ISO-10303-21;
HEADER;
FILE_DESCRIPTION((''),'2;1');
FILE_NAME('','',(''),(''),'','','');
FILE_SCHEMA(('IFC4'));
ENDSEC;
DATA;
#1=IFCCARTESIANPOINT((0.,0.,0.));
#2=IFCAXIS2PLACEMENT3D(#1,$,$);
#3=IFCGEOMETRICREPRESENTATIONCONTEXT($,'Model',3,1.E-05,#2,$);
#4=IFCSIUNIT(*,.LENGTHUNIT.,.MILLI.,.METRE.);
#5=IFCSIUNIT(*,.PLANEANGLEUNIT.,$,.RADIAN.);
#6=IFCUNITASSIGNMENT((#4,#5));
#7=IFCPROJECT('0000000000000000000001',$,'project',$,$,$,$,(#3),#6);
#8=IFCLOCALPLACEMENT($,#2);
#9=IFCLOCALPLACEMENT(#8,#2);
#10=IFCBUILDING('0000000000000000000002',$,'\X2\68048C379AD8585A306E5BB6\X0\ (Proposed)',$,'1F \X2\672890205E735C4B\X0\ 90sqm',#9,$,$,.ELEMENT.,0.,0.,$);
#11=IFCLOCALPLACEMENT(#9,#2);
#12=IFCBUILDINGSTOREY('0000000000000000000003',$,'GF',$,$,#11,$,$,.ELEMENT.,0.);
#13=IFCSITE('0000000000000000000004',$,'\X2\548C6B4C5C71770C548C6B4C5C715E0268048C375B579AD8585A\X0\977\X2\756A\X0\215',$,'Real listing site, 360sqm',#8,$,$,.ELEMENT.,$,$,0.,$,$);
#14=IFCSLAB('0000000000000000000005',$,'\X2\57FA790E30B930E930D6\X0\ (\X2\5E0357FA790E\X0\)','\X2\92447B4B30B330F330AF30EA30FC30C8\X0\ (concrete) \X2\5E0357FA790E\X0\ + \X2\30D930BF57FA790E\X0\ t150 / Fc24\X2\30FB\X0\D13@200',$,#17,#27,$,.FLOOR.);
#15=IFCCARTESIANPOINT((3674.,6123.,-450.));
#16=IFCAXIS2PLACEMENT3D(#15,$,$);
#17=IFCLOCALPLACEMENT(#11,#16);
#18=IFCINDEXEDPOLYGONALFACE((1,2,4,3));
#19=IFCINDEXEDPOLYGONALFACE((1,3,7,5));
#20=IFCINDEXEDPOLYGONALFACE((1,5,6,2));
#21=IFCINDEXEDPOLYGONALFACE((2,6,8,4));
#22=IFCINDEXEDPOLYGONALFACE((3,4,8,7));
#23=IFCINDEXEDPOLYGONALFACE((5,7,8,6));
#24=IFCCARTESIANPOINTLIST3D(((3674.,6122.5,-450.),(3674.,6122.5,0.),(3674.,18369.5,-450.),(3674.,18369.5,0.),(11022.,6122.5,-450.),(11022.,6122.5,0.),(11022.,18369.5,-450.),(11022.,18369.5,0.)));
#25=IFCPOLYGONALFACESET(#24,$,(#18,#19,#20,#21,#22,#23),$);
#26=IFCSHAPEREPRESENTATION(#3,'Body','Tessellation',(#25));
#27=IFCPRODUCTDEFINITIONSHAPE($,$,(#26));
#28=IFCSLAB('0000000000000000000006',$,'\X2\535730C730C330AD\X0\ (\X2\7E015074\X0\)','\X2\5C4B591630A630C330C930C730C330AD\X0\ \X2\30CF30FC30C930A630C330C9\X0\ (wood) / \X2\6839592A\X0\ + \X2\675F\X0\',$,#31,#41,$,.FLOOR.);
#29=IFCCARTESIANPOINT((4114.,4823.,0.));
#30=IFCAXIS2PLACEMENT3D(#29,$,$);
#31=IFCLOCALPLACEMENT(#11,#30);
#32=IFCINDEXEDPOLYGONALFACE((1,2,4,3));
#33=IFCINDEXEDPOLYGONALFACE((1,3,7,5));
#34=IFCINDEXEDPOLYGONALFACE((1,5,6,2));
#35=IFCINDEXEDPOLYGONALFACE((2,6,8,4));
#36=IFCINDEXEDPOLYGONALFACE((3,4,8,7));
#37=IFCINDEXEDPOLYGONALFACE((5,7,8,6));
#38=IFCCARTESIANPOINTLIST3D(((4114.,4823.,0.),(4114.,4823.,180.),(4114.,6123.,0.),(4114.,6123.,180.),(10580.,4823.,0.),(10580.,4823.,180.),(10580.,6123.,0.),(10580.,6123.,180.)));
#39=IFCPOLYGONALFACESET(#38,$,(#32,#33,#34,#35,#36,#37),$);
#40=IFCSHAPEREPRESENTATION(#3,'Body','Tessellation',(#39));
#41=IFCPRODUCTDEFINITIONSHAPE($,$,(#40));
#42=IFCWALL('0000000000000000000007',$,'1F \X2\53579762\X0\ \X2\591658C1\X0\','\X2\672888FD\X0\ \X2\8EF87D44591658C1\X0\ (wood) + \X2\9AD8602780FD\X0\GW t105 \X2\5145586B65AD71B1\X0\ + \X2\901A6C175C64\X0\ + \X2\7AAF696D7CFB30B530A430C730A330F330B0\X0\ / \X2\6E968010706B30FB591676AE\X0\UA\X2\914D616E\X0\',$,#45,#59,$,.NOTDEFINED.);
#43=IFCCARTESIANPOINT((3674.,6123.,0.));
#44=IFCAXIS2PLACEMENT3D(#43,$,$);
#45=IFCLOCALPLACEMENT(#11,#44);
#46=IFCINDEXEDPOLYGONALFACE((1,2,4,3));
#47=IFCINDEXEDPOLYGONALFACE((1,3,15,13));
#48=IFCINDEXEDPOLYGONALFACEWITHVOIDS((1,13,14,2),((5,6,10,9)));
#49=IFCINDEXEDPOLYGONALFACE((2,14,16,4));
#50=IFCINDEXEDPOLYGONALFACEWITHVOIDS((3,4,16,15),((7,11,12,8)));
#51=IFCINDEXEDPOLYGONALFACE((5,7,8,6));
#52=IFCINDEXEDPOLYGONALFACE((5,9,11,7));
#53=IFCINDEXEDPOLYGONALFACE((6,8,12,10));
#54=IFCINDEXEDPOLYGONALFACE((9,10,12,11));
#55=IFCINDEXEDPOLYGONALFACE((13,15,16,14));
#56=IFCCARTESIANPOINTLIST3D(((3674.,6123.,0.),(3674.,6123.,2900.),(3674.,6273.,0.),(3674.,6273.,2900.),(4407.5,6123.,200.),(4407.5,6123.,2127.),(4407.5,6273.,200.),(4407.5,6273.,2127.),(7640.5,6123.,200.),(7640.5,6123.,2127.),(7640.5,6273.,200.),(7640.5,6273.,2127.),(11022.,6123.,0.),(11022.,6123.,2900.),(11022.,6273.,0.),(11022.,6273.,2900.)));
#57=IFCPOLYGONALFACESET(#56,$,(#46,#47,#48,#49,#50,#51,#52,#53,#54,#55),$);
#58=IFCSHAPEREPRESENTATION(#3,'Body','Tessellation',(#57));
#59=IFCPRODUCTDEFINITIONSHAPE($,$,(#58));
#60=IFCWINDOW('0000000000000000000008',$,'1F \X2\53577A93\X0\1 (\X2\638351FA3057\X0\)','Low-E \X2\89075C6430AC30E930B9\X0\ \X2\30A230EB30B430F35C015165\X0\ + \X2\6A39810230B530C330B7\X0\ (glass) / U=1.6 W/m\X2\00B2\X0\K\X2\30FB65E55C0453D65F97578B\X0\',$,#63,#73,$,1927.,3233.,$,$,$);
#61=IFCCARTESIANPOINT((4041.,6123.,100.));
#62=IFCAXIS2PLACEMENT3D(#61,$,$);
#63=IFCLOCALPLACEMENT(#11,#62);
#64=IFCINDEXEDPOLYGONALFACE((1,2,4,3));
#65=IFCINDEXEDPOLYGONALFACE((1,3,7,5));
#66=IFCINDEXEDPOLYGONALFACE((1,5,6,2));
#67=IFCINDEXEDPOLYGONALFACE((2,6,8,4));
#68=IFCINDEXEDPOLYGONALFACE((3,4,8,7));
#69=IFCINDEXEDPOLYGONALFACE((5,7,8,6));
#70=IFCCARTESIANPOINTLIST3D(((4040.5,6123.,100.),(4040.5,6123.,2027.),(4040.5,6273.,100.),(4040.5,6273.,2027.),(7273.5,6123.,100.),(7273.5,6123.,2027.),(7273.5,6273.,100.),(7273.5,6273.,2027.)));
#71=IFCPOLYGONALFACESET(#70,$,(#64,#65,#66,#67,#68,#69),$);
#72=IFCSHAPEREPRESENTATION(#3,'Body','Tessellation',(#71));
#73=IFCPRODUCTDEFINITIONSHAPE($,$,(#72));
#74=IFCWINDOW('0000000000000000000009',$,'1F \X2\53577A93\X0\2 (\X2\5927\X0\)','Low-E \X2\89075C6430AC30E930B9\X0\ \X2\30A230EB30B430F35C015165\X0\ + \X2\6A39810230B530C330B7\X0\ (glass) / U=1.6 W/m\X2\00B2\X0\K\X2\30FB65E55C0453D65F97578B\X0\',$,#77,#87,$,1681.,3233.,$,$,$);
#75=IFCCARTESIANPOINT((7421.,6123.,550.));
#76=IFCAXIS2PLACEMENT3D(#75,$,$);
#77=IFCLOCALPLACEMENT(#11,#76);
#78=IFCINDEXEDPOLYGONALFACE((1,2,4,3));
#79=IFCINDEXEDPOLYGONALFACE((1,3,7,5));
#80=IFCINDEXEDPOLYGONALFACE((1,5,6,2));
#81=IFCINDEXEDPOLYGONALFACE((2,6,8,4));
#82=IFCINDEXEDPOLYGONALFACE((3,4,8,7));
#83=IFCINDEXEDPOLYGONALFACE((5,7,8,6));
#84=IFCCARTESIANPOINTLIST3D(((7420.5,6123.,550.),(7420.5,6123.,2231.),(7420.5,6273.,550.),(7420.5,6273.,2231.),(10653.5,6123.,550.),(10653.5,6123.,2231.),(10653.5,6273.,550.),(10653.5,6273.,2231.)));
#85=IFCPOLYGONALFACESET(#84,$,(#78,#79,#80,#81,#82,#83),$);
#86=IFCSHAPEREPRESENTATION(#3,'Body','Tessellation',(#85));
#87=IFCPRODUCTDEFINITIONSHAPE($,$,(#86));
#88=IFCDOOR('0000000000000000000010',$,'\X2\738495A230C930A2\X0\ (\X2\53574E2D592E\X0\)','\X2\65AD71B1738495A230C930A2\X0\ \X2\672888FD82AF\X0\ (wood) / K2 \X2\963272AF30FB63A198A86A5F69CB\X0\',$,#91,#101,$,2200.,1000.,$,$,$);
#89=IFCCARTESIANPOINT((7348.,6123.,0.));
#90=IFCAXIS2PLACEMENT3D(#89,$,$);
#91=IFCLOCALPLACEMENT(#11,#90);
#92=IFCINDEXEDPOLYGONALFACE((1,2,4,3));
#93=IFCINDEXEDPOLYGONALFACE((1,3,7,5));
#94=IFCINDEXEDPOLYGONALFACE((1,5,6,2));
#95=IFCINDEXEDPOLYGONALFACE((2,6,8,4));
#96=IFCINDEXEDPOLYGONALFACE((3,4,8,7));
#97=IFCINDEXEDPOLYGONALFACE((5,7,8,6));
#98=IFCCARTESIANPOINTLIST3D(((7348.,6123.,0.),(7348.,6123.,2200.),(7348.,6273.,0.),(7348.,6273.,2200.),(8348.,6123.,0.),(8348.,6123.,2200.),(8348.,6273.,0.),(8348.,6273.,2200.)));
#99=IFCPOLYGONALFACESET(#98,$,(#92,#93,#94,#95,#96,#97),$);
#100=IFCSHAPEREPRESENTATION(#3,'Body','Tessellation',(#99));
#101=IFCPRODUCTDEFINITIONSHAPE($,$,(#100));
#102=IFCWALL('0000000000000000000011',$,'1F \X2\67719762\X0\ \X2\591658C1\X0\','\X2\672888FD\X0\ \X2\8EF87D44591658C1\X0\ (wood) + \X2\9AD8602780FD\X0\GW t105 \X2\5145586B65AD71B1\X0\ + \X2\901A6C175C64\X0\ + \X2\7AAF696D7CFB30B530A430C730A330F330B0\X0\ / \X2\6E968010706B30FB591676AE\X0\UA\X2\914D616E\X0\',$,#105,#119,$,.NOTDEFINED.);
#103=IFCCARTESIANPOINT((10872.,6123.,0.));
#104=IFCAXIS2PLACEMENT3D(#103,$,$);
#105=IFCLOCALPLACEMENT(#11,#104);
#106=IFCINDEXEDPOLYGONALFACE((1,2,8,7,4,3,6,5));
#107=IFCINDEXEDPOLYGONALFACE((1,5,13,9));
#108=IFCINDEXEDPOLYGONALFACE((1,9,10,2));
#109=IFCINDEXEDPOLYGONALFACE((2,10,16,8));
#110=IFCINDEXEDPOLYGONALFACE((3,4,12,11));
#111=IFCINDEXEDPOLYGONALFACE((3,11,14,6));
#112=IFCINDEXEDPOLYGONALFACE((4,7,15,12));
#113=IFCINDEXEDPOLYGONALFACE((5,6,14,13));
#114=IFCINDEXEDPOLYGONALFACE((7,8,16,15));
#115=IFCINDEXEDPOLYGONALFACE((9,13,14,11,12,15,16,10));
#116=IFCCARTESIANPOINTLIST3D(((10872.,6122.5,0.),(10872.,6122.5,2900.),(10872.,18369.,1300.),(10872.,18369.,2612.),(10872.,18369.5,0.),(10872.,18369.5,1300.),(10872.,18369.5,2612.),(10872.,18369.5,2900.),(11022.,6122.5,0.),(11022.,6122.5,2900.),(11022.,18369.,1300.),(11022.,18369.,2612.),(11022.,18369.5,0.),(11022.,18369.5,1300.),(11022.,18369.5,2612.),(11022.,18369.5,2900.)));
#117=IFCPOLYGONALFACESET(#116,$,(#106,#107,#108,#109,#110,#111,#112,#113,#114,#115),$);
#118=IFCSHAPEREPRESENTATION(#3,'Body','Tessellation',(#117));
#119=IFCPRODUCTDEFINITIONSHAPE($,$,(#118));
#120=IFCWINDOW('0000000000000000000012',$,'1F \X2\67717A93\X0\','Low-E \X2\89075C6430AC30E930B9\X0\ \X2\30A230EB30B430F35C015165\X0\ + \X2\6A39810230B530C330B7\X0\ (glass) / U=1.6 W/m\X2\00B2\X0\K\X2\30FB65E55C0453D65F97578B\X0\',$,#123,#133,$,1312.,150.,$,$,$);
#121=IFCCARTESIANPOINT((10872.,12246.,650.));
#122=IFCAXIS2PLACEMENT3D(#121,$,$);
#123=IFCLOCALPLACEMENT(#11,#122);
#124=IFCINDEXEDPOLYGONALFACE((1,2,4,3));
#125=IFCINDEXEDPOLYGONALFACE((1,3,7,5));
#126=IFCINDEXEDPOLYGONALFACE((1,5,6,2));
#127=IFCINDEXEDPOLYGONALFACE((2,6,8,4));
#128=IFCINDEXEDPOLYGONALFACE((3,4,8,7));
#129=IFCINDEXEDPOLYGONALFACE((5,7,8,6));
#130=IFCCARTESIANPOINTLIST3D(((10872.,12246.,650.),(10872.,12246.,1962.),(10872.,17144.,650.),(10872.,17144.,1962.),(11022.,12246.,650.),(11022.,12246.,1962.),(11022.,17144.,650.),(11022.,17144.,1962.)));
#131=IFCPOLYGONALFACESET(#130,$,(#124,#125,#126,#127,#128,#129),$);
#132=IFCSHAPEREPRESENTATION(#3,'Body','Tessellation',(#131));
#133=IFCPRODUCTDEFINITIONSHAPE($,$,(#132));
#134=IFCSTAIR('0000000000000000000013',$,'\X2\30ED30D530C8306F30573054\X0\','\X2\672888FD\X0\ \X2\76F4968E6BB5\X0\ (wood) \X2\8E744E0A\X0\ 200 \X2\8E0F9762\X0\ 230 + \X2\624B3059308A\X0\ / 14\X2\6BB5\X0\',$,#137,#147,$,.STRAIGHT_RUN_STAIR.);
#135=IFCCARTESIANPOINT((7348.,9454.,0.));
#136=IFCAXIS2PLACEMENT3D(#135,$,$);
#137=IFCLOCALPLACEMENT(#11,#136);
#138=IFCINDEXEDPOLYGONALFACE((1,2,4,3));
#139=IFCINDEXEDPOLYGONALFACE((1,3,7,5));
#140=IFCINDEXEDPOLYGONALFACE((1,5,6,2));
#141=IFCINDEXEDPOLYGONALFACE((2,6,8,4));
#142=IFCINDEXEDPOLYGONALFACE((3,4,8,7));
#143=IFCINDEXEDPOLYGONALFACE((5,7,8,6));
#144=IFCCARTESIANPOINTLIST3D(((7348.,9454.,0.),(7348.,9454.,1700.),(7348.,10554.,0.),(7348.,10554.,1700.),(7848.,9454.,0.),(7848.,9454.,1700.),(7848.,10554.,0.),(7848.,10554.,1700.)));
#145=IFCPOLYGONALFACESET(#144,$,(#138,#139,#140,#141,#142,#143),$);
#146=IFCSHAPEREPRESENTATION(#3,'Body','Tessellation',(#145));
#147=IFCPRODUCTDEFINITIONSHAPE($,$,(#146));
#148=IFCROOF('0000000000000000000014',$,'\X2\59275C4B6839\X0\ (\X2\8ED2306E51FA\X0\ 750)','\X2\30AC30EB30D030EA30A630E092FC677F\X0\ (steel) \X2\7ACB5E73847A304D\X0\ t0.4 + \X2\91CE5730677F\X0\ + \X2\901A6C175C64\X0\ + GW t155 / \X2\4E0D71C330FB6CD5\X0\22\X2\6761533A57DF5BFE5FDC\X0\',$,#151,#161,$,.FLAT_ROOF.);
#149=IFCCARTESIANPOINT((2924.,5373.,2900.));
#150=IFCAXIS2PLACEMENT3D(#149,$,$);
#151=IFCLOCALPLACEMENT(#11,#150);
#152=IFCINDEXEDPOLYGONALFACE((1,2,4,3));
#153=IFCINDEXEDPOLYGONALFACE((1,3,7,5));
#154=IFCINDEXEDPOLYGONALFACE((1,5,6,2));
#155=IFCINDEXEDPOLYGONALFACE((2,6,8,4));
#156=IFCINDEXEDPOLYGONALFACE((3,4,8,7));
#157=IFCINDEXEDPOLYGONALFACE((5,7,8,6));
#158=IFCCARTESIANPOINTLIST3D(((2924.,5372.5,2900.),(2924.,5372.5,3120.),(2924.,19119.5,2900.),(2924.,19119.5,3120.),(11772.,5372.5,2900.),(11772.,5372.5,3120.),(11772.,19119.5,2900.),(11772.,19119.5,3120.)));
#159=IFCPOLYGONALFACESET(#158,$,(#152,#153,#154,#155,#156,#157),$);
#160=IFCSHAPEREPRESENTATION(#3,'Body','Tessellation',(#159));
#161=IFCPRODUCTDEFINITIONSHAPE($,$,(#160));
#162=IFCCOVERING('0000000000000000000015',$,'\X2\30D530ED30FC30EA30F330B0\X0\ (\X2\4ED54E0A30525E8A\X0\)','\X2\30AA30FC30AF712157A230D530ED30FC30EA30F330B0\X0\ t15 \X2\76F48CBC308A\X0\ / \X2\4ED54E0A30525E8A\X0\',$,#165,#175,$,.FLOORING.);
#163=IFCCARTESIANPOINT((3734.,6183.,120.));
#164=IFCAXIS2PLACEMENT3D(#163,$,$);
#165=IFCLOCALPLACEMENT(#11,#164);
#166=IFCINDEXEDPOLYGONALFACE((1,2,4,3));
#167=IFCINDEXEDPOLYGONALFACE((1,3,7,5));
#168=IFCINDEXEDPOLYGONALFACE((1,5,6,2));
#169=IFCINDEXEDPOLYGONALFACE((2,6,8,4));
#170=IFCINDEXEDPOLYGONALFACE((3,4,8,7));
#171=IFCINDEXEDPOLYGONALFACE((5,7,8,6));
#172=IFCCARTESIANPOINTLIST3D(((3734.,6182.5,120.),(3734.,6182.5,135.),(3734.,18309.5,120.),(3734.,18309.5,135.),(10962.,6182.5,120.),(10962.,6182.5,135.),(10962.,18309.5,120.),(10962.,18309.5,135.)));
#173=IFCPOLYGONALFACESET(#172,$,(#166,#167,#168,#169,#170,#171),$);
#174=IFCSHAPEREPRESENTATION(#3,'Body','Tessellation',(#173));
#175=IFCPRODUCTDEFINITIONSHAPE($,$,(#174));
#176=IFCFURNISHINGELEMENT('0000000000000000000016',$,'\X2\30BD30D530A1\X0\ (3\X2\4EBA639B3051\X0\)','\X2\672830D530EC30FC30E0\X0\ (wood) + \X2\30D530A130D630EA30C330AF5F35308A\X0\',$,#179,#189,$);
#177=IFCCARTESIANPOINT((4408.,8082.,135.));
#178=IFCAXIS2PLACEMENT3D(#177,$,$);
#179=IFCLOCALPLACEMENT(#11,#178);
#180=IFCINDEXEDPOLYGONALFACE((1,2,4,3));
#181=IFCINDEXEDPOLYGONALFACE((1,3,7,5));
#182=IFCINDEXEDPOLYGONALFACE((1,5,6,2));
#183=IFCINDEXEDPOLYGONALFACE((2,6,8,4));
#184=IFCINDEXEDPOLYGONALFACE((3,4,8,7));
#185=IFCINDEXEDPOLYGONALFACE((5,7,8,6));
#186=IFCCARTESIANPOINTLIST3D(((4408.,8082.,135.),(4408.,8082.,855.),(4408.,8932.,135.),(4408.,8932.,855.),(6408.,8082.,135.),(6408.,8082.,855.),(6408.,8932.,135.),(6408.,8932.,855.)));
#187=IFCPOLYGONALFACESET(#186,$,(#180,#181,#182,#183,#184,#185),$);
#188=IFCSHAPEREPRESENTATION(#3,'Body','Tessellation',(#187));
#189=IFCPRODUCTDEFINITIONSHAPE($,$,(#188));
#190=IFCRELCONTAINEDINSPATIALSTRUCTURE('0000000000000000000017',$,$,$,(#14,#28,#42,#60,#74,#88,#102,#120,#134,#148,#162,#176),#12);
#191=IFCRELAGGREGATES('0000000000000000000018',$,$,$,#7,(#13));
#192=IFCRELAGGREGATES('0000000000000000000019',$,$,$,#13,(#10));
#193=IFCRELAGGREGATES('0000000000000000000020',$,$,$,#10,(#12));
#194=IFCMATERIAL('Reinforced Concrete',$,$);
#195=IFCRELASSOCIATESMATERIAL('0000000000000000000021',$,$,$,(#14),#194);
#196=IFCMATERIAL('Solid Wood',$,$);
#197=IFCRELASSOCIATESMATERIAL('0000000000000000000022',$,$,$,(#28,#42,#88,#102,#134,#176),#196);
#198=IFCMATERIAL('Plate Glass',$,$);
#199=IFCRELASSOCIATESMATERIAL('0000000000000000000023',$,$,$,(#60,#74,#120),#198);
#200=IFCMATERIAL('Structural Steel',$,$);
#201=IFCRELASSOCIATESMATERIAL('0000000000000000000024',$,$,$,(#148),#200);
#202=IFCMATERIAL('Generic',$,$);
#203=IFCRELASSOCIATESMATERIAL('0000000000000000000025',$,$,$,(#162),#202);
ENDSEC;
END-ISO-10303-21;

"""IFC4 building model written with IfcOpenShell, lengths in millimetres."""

from ifc_helpers import new_model, si_unit, frame, frame_2d, origin, place, context, project, spatial, rectangle, extrude, material, element, fill, save


model = new_model("IFC4")

# Units and contexts
model_context = context("Model", 3, precision=1e-05, world=origin())
ifc_project = project(units=[si_unit("LENGTHUNIT", "METRE", prefix="MILLI"), si_unit("PLANEANGLEUNIT", "RADIAN")], contexts=[model_context])

# Site, building, storey
site_placement = place(None, origin())
site = spatial("IfcSite", under=ifc_project, at=site_placement, Name="和歌山県和歌山市栄谷字高塚977番215", ObjectType="Real listing site, 360sqm", CompositionType="ELEMENT", RefElevation=0.0)
building_placement = place(site_placement, origin())
building = spatial("IfcBuilding", under=site, at=building_placement, Name="栄谷高塚の家 (Proposed)", ObjectType="1F 木造平屋 90sqm", CompositionType="ELEMENT", ElevationOfRefHeight=0.0, ElevationOfTerrain=0.0)
storey_placement = place(building_placement, origin())
storey = spatial("IfcBuildingStorey", under=building, at=storey_placement, Name="GF", CompositionType="ELEMENT", Elevation=0.0)

# Slabs
ifc_material_1 = material(Name="Reinforced Concrete")
slab_1_placement = place(storey_placement, frame((3674.0, 6123.0, -450.0)))
element("IfcSlab", 1, at=slab_1_placement, inside=storey, material=ifc_material_1, Name="基礎スラブ (布基礎)", Description="鉄筋コンクリート (concrete) 布基礎 + ベタ基礎 t150 / Fc24・D13@200", PredefinedType="FLOOR", context=model_context, shape_type="SweptSolid", body=[
    extrude(rectangle(XDim=7348.0, YDim=12247.0, at=frame_2d((3674.0, 6123.0))), frame((3674.0, 6123.0, -450.0)), (0.0, 0.0, 1.0), 450.0),
])
ifc_material_2 = material(Name="Solid Wood")
slab_2_placement = place(storey_placement, frame((4114.0, 4823.0, 0.0)))
element("IfcSlab", 2, at=slab_2_placement, inside=storey, material=ifc_material_2, Name="南デッキ (縁側)", Description="屋外ウッドデッキ ハードウッド (wood) / 根太 + 束", PredefinedType="FLOOR", context=model_context, shape_type="SweptSolid", body=[
    extrude(rectangle(XDim=6466.0, YDim=1300.0, at=frame_2d((3233.0, 650.0))), frame((4114.0, 4823.0, 0.0)), (0.0, 0.0, 1.0), 180.0),
])

# Wall, openings, windows, door
wall_1_placement = place(storey_placement, frame((3674.0, 6123.0, 0.0)))
wall_1 = element("IfcWall", 3, at=wall_1_placement, inside=storey, material=ifc_material_2, Name="1F 南面 外壁", Description="木製 軸組外壁 (wood) + 高性能GW t105 充填断熱 + 通気層 + 窯業系サイディング / 準耐火・外皮UA配慮", PredefinedType="NOTDEFINED", context=model_context, shape_type="SweptSolid", body=[
    extrude(rectangle(XDim=7348.0, YDim=150.0, at=frame_2d((3674.0, 75.0))), frame((3674.0, 6123.0, 0.0)), (0.0, 0.0, 1.0), 2900.0),
])
opening_1_placement = place(storey_placement, frame((4041.0, 6123.0, 100.0)))
opening_1 = element("IfcOpeningElement", 4, at=opening_1_placement, cuts=wall_1, PredefinedType="NOTDEFINED", context=model_context, shape_type="SweptSolid", body=[
    extrude(rectangle(XDim=3233.0, YDim=150.0, at=frame_2d((1616.0, 75.0))), frame((4041.0, 6123.0, 100.0)), (0.0, 0.0, 1.0), 1927.0),
])
opening_2_placement = place(storey_placement, frame((7421.0, 6123.0, 550.0)))
opening_2 = element("IfcOpeningElement", 5, at=opening_2_placement, cuts=wall_1, PredefinedType="NOTDEFINED", context=model_context, shape_type="SweptSolid", body=[
    extrude(rectangle(XDim=3233.0, YDim=150.0, at=frame_2d((1616.0, 75.0))), frame((7421.0, 6123.0, 550.0)), (0.0, 0.0, 1.0), 1681.0),
])
opening_3_placement = place(storey_placement, frame((7348.0, 6123.0, 0.0)))
opening_3 = element("IfcOpeningElement", 6, at=opening_3_placement, cuts=wall_1, PredefinedType="NOTDEFINED", context=model_context, shape_type="SweptSolid", body=[
    extrude(rectangle(XDim=1000.0, YDim=150.0, at=frame_2d((500.0, 75.0))), frame((7348.0, 6123.0, 0.0)), (0.0, 0.0, 1.0), 2200.0),
])
ifc_material_3 = material(Name="Plate Glass")
window_1_placement = place(storey_placement, frame((4041.0, 6123.0, 100.0)))
window_1 = element("IfcWindow", 7, at=window_1_placement, inside=storey, material=ifc_material_3, Name="1F 南窓1 (掃出し)", Description="Low-E 複層ガラス アルゴン封入 + 樹脂サッシ (glass) / U=1.6 W/m²K・日射取得型", OverallHeight=1927.0, OverallWidth=3233.0, context=model_context, shape_type="SweptSolid", body=[
    extrude(rectangle(XDim=3233.0, YDim=150.0, at=frame_2d((1616.0, 75.0))), frame((4041.0, 6123.0, 100.0)), (0.0, 0.0, 1.0), 1927.0),
])
fill(opening_1, window_1)
window_2_placement = place(storey_placement, frame((7421.0, 6123.0, 550.0)))
window_2 = element("IfcWindow", 8, at=window_2_placement, inside=storey, material=ifc_material_3, Name="1F 南窓2 (大)", Description="Low-E 複層ガラス アルゴン封入 + 樹脂サッシ (glass) / U=1.6 W/m²K・日射取得型", OverallHeight=1681.0, OverallWidth=3233.0, context=model_context, shape_type="SweptSolid", body=[
    extrude(rectangle(XDim=3233.0, YDim=150.0, at=frame_2d((1616.0, 75.0))), frame((7421.0, 6123.0, 550.0)), (0.0, 0.0, 1.0), 1681.0),
])
fill(opening_2, window_2)
door_placement = place(storey_placement, frame((7348.0, 6123.0, 0.0)))
door = element("IfcDoor", 9, at=door_placement, inside=storey, material=ifc_material_2, Name="玄関ドア (南中央)", Description="断熱玄関ドア 木製芯 (wood) / K2 防犯・採風機構", OverallHeight=2200.0, OverallWidth=1000.0, context=model_context, shape_type="SweptSolid", body=[
    extrude(rectangle(XDim=1000.0, YDim=150.0, at=frame_2d((500.0, 75.0))), frame((7348.0, 6123.0, 0.0)), (0.0, 0.0, 1.0), 2200.0),
])
fill(opening_3, door)

# Wall, opening, window
wall_2_placement = place(storey_placement, frame((10872.0, 6123.0, 0.0)))
wall_2 = element("IfcWall", 10, at=wall_2_placement, inside=storey, material=ifc_material_2, Name="1F 東面 外壁", Description="木製 軸組外壁 (wood) + 高性能GW t105 充填断熱 + 通気層 + 窯業系サイディング / 準耐火・外皮UA配慮", PredefinedType="NOTDEFINED", context=model_context, shape_type="SweptSolid", body=[
    extrude(rectangle(XDim=150.0, YDim=12247.0, at=frame_2d((75.0, 6123.0))), frame((10872.0, 6123.0, 0.0)), (0.0, 0.0, 1.0), 2900.0),
])
opening_4_placement = place(storey_placement, frame((10872.0, 12246.0, 650.0)))
opening_4 = element("IfcOpeningElement", 11, at=opening_4_placement, cuts=wall_2, PredefinedType="NOTDEFINED", context=model_context, shape_type="SweptSolid", body=[
    extrude(rectangle(XDim=150.0, YDim=4898.0, at=frame_2d((75.0, 2449.0))), frame((10872.0, 12246.0, 650.0)), (0.0, 0.0, 1.0), 1312.0),
])
window_3_placement = place(storey_placement, frame((10872.0, 12246.0, 650.0)))
window_3 = element("IfcWindow", 12, at=window_3_placement, inside=storey, material=ifc_material_3, Name="1F 東窓", Description="Low-E 複層ガラス アルゴン封入 + 樹脂サッシ (glass) / U=1.6 W/m²K・日射取得型", OverallHeight=1312.0, OverallWidth=150.0, context=model_context, shape_type="SweptSolid", body=[
    extrude(rectangle(XDim=150.0, YDim=4898.0, at=frame_2d((75.0, 2449.0))), frame((10872.0, 12246.0, 650.0)), (0.0, 0.0, 1.0), 1312.0),
])
fill(opening_4, window_3)

# Stair
stair_placement = place(storey_placement, frame((7348.0, 9454.0, 0.0)))
element("IfcStair", 13, at=stair_placement, inside=storey, material=ifc_material_2, Name="ロフトはしご", Description="木製 直階段 (wood) 蹴上 200 踏面 230 + 手すり / 14段", PredefinedType="STRAIGHT_RUN_STAIR", context=model_context, shape_type="SweptSolid", body=[
    extrude(rectangle(XDim=500.0, YDim=1100.0, at=frame_2d((250.0, 550.0))), frame((7348.0, 9454.0, 0.0)), (0.0, 0.0, 1.0), 1700.0),
])

# Roof
ifc_material_4 = material(Name="Structural Steel")
roof_placement = place(storey_placement, frame((2924.0, 5373.0, 2900.0)))
element("IfcRoof", 14, at=roof_placement, inside=storey, material=ifc_material_4, Name="大屋根 (軒の出 750)", Description="ガルバリウム鋼板 (steel) 立平葺き t0.4 + 野地板 + 通気層 + GW t155 / 不燃・法22条区域対応", PredefinedType="FLAT_ROOF", context=model_context, shape_type="SweptSolid", body=[
    extrude(rectangle(XDim=8848.0, YDim=13747.0, at=frame_2d((4424.0, 6873.0))), frame((2924.0, 5373.0, 2900.0)), (0.0, 0.0, 1.0), 220.0),
])

# Covering
ifc_material_5 = material(Name="Generic")
covering_placement = place(storey_placement, frame((3734.0, 6183.0, 120.0)))
element("IfcCovering", 15, at=covering_placement, inside=storey, material=ifc_material_5, Name="フローリング (仕上げ床)", Description="オーク無垢フローリング t15 直貼り / 仕上げ床", PredefinedType="FLOORING", context=model_context, shape_type="SweptSolid", body=[
    extrude(rectangle(XDim=7228.0, YDim=12127.0, at=frame_2d((3614.0, 6063.0))), frame((3734.0, 6183.0, 120.0)), (0.0, 0.0, 1.0), 15.0),
])

# Furnishing element
furnishing_1_placement = place(storey_placement, frame((4408.0, 8082.0, 135.0)))
element("IfcFurnishingElement", 16, at=furnishing_1_placement, inside=storey, material=ifc_material_2, Name="ソファ (3人掛け)", Description="木フレーム (wood) + ファブリック張り", context=model_context, shape_type="SweptSolid", body=[
    extrude(rectangle(XDim=2000.0, YDim=850.0, at=frame_2d((1000.0, 425.0))), frame((4408.0, 8082.0, 135.0)), (0.0, 0.0, 1.0), 720.0),
])

save(model, "model.ifc")
